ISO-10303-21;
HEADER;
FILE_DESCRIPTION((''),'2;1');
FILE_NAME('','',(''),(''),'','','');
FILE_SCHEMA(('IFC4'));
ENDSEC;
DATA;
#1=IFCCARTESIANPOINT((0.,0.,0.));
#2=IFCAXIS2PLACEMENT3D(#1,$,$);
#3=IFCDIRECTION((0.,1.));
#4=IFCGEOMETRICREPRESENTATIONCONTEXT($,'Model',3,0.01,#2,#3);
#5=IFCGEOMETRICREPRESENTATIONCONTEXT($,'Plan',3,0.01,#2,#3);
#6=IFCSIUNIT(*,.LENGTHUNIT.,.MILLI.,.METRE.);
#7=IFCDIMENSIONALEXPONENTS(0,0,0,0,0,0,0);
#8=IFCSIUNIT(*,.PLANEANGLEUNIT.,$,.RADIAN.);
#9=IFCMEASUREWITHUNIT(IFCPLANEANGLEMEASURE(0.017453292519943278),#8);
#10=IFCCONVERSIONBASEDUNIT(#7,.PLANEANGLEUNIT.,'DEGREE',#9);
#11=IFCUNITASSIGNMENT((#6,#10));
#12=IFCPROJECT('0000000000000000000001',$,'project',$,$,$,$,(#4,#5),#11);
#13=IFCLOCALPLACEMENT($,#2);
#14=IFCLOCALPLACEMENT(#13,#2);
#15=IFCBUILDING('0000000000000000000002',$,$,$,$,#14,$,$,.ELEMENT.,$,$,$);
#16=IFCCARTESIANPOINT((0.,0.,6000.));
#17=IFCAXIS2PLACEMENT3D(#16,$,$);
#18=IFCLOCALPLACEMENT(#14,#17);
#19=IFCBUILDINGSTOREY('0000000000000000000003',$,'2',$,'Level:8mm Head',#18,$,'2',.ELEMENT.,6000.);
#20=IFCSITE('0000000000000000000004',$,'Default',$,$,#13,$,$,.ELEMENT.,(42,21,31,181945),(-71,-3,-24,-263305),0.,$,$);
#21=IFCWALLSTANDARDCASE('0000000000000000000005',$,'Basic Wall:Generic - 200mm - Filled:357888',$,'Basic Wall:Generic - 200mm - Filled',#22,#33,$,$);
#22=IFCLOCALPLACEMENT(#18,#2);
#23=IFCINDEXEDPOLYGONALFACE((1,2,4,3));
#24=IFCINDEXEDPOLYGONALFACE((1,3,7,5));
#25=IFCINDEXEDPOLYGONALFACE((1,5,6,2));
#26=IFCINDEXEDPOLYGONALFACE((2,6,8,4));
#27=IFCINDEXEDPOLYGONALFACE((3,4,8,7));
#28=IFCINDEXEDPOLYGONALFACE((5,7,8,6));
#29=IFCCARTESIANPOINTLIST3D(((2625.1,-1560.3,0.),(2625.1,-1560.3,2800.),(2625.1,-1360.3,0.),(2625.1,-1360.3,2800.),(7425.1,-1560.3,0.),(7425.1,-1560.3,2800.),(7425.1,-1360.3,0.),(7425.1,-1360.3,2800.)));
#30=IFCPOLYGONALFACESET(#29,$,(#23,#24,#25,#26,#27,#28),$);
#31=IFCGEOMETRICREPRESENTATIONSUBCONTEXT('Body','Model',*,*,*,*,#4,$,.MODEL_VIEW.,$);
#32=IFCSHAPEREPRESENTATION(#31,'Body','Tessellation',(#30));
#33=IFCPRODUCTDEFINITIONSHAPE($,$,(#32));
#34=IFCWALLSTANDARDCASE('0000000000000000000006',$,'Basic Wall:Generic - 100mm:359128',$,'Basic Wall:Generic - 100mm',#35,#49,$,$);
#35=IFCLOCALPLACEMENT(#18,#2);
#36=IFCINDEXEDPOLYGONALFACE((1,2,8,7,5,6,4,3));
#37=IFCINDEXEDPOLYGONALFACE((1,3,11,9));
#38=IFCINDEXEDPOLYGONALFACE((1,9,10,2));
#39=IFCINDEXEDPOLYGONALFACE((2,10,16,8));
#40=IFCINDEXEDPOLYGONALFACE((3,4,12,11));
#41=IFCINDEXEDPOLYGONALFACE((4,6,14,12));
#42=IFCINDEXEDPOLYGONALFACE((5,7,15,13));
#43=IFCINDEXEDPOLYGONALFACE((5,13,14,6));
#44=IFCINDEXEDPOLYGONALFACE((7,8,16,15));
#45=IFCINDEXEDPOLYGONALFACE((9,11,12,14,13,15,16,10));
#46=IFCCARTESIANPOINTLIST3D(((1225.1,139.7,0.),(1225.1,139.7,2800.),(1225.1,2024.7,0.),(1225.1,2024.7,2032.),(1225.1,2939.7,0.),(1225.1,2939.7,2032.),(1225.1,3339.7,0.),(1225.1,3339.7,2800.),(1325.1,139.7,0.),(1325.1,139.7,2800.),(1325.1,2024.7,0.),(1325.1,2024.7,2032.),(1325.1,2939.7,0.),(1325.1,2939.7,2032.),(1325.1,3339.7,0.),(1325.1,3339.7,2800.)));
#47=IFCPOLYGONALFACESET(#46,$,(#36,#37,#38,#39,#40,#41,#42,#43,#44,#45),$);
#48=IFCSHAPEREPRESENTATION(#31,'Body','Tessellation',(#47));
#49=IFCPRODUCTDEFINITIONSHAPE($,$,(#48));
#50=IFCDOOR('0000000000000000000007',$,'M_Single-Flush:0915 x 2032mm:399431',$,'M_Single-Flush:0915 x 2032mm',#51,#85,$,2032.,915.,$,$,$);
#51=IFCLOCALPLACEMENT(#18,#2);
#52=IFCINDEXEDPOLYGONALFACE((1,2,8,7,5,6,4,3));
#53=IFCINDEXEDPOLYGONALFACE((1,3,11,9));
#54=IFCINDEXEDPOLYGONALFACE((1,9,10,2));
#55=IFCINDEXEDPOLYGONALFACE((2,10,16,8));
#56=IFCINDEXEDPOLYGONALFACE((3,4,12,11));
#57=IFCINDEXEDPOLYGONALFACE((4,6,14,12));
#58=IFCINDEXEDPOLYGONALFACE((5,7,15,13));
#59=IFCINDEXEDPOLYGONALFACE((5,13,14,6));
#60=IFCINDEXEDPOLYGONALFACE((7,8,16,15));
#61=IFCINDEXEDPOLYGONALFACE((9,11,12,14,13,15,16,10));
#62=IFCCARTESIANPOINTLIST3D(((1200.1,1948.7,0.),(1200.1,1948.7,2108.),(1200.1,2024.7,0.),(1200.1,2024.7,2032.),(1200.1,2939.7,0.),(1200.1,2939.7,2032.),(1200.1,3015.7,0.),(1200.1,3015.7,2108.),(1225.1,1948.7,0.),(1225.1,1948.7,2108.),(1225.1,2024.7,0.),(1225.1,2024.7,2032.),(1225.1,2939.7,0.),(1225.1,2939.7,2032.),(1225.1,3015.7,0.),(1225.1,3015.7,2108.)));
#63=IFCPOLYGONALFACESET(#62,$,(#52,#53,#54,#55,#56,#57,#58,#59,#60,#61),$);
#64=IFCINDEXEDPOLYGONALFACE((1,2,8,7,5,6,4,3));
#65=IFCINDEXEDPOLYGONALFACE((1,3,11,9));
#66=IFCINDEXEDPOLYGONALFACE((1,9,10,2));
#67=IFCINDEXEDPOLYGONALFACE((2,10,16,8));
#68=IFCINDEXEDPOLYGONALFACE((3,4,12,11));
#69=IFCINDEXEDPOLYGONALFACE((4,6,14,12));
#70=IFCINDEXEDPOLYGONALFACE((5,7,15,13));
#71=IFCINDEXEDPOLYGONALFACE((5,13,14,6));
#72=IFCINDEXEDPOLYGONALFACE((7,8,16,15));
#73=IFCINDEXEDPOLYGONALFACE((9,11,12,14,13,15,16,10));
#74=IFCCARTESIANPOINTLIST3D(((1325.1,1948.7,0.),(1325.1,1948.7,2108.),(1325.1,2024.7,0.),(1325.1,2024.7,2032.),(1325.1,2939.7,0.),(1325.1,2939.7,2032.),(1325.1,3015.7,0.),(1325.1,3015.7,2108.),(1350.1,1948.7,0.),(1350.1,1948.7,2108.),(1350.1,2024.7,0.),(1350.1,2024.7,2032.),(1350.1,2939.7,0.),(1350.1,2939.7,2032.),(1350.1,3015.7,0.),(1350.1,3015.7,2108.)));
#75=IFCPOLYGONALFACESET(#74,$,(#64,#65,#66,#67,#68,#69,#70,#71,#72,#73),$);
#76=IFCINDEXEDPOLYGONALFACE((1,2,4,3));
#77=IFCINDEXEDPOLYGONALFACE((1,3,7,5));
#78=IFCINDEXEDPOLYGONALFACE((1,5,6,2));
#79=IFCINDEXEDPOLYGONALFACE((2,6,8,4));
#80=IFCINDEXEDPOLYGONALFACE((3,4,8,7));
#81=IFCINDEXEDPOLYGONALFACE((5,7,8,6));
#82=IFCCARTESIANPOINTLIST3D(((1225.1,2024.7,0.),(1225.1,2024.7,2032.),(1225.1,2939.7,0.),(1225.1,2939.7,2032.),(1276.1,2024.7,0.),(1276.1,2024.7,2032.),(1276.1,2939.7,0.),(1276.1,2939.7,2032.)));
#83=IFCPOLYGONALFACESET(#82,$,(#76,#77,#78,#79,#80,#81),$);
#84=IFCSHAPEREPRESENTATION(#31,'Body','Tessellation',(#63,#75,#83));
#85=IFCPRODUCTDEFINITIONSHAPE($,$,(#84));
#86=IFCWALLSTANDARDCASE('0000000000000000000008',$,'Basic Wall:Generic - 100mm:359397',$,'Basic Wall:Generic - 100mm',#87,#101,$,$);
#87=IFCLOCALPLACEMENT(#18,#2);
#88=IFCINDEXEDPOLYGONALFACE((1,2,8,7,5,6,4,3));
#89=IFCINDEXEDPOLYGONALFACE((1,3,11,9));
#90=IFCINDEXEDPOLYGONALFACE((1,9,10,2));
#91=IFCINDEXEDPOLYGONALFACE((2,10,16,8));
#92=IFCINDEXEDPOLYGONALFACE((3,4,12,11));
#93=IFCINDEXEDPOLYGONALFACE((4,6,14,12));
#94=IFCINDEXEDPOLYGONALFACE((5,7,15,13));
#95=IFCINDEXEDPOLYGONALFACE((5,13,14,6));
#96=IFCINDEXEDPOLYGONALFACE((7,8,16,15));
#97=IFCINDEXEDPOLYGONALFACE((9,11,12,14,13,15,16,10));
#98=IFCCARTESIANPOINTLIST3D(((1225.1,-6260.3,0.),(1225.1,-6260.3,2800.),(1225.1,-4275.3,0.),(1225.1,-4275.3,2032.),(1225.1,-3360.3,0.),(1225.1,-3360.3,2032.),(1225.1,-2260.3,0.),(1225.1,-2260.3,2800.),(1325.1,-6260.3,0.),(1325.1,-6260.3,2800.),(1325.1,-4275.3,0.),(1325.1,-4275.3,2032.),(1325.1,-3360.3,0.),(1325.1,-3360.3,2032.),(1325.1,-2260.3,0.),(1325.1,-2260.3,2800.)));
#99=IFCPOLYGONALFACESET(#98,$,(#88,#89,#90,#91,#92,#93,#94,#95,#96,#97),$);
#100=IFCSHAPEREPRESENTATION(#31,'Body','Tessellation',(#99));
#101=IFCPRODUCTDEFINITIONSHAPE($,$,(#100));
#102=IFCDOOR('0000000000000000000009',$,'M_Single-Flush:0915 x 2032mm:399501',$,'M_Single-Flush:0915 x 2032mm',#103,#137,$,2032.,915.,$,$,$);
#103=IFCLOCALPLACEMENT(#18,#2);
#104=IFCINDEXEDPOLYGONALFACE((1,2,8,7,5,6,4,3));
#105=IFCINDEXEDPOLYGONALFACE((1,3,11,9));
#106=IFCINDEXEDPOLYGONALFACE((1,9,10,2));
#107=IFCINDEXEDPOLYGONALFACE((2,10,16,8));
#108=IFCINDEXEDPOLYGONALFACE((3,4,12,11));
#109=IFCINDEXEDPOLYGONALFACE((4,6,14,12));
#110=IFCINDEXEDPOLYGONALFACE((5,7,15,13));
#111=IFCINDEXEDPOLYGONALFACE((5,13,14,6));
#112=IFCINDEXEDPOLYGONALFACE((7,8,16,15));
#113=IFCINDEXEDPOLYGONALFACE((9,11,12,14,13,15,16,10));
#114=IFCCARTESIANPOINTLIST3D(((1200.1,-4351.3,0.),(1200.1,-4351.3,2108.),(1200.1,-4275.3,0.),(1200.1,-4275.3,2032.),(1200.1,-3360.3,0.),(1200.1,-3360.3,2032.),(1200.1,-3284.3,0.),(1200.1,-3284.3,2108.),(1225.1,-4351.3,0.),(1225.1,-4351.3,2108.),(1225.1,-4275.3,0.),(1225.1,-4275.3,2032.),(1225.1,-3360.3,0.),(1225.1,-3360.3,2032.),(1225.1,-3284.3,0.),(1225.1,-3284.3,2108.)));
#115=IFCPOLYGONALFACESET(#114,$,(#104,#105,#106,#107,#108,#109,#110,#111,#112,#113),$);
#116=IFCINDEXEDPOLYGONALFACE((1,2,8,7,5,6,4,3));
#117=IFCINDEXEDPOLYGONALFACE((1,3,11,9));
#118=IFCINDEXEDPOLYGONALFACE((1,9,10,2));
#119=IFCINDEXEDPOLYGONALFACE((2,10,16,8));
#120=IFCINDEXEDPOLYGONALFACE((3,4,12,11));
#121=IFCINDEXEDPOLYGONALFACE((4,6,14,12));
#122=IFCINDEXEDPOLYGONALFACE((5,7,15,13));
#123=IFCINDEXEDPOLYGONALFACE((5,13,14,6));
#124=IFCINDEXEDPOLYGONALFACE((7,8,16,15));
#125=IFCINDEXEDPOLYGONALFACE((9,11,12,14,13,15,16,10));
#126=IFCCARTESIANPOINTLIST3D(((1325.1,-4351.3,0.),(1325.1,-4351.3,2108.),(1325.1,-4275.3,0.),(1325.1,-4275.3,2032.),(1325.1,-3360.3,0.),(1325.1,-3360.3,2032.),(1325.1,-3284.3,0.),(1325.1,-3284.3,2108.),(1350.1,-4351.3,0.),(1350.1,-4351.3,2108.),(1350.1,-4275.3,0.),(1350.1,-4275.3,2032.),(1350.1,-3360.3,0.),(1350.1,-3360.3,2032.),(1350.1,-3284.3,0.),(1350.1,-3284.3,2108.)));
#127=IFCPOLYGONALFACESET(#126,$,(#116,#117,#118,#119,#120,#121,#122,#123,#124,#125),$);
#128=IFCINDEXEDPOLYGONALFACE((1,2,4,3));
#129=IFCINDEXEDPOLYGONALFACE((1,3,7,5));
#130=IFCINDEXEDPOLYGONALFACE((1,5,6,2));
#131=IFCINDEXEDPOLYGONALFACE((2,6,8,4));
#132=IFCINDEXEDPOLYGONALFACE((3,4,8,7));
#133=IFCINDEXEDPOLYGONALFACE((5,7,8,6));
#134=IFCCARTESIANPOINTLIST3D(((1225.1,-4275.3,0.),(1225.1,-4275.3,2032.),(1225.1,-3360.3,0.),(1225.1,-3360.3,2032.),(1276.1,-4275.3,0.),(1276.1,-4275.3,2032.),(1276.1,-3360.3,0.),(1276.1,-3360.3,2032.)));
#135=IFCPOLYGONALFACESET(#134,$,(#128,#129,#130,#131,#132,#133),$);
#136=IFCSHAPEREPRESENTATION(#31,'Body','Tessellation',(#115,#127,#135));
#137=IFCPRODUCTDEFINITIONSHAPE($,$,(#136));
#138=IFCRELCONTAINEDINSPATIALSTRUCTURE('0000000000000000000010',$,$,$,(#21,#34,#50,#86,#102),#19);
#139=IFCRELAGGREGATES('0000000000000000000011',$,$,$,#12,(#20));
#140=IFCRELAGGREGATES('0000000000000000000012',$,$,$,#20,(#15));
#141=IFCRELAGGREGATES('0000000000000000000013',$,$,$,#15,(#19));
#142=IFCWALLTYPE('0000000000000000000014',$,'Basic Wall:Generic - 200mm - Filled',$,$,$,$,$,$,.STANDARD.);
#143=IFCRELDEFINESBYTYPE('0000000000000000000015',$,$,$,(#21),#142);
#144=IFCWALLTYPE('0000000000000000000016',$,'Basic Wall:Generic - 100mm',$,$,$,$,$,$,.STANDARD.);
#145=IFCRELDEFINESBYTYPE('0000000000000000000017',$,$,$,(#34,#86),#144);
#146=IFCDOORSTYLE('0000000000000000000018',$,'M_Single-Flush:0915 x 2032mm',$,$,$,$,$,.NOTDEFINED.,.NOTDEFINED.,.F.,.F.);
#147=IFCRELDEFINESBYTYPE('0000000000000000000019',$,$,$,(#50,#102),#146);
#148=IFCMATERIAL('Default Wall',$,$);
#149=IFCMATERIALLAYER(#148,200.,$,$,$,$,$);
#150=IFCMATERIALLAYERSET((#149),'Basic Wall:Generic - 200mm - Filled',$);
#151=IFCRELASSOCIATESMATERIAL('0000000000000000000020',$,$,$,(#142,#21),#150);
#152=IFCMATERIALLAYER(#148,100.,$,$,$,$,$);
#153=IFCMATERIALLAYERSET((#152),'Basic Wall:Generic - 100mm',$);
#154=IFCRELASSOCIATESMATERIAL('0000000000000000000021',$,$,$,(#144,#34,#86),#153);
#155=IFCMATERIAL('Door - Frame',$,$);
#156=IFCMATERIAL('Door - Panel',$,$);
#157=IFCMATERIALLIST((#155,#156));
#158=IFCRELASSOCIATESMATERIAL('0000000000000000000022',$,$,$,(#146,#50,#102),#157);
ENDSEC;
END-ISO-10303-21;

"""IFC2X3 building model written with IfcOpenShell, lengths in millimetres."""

from ifc_helpers import new_model, entity, si_unit, converted_unit, direction, frame, frame_2d, origin, origin_2d_with_axis, place, context, subcontext, project, spatial, polyline, rectangle, outline, extrude, source, transform, mapped, material, material_list, layer, layer_set, layer_usage, type_object, type_shapes, element, fill, save


model = new_model("IFC2X3")

# Units and contexts
model_context = context("Model", 3, precision=0.01, world=origin(), true_north=direction((0.0, 1.0)))
plan_context = context("Plan", 3, precision=0.01, world=origin(), true_north=direction((0.0, 1.0)))
body_context = subcontext(model_context, "Body", "Model", "MODEL_VIEW")
ifc_project = project(units=[si_unit("LENGTHUNIT", "METRE", prefix="MILLI"), converted_unit("PLANEANGLEUNIT", "DEGREE", entity("IfcPlaneAngleMeasure", 0.017453292519943278), si_unit("PLANEANGLEUNIT", "RADIAN"), dimensions=[0, 0, 0, 0, 0, 0, 0])], contexts=[model_context, plan_context])

# Site, building, storey
site_placement = place(None, origin())
site = spatial("IfcSite", under=ifc_project, at=site_placement, Name="Default", CompositionType="ELEMENT", RefLatitude=(42, 21, 31, 181945), RefLongitude=(-71, -3, -24, -263305), RefElevation=0.0)
building_placement = place(site_placement, origin())
building = spatial("IfcBuilding", under=site, at=building_placement, CompositionType="ELEMENT")
storey_placement = place(building_placement, frame((0.0, 0.0, 6000.0)))
storey = spatial("IfcBuildingStorey", under=building, at=storey_placement, Name="2", ObjectType="Level:8mm Head", LongName="2", CompositionType="ELEMENT", Elevation=6000.0)

# Shared definitions
ifc_material_1 = material(Name="Default Wall")
ifc_layer_1 = layer(ifc_material_1, 200.0)
ifc_layer_set_1 = layer_set([ifc_layer_1], Name="Basic Wall:Generic - 200mm - Filled")
ifc_layer_usage_1 = layer_usage(ifc_layer_set_1, "AXIS2", "NEGATIVE", 100.0)
wall_type_1 = type_object("IfcWallType", Name="Basic Wall:Generic - 200mm - Filled", PredefinedType="STANDARD", material=ifc_layer_set_1)
ifc_material_2 = material(Name="Door - Frame")
ifc_material_3 = material(Name="Door - Panel")
ifc_material_list = material_list([ifc_material_2, ifc_material_3])

# Wall
wall_1_placement = place(storey_placement, frame((2625.1, -1460.3, 0.0)))
element("IfcWallStandardCase", 1, at=wall_1_placement, inside=storey, type_object=wall_type_1, material=ifc_layer_usage_1, Name="Basic Wall:Generic - 200mm - Filled:357888", ObjectType="Basic Wall:Generic - 200mm - Filled", context=body_context, shape_type="SweptSolid", body=[
    extrude(rectangle(XDim=4800.0, YDim=200.0, at=frame_2d((2400.0, 0.0), x_axis=(-1.0, 0.0))), origin(), (0.0, 0.0, 1.0), 2800.0),
])

# Walls, openings, doors
ifc_layer_2 = layer(ifc_material_1, 100.0)
ifc_layer_set_2 = layer_set([ifc_layer_2], Name="Basic Wall:Generic - 100mm")
ifc_layer_usage_2 = layer_usage(ifc_layer_set_2, "AXIS2", "NEGATIVE", 50.0)
wall_type_2 = type_object("IfcWallType", Name="Basic Wall:Generic - 100mm", PredefinedType="STANDARD", material=ifc_layer_set_2)
wall_2_placement = place(storey_placement, frame((1275.1, 139.7, 0.0), z_axis=(0.0, 0.0, 1.0), x_axis=(0.0, 1.0, 0.0)))
wall_2 = element("IfcWallStandardCase", 2, at=wall_2_placement, inside=storey, type_object=wall_type_2, material=ifc_layer_usage_2, Name="Basic Wall:Generic - 100mm:359128", ObjectType="Basic Wall:Generic - 100mm", context=body_context, shape_type="SweptSolid", body=[
    extrude(rectangle(XDim=3200.0, YDim=100.0, at=frame_2d((1600.0, 0.0), x_axis=(-1.0, 0.0))), origin(), (0.0, 0.0, 1.0), 2800.0),
])
opening_1_placement = place(wall_2_placement, frame((1885.0, -50.0, 0.0)))
opening_1 = element("IfcOpeningElement", 3, at=opening_1_placement, cuts=wall_2, ObjectType="Opening", context=body_context, shape_type="SweptSolid", body=[
    extrude(rectangle(XDim=915.0, YDim=2032.0, at=frame_2d((1016.0, 457.5), x_axis=(0.0, 1.0))), frame((0.0, 0.0, 0.0), z_axis=(0.0, 1.0, 0.0), x_axis=(0.0, 0.0, 1.0)), (0.0, 0.0, 1.0), 100.0),
])
door_style_1 = type_object("IfcDoorStyle", Name="M_Single-Flush:0915 x 2032mm", ConstructionType="NOTDEFINED", OperationType="NOTDEFINED", ParameterTakesPrecedence=False, Sizeable=False, material=ifc_material_list)
shared_shape_1 = source(origin(), body_context, "Body", "SweptSolid", [
    extrude(outline(polyline([(-533.5, -1073.0), (533.5, -1073.0), (533.5, 1035.0), (457.5, 1035.0), (457.5, -997.0), (-457.5, -997.0), (-457.5, 1035.0), (-533.5, 1035.0), (-533.5, -1073.0)])), frame((457.5, 100.0, 1035.0), z_axis=(0.0, 1.0, 0.0), x_axis=(1.0, 0.0, 0.0)), (0.0, 0.0, 1.0), 25.0),
    extrude(outline(polyline([(-1073.0, -533.5), (1035.0, -533.5), (1035.0, -457.5), (-997.0, -457.5), (-997.0, 457.5), (1035.0, 457.5), (1035.0, 533.5), (-1073.0, 533.5), (-1073.0, -533.5)])), frame((457.5, -25.0, 1035.0), z_axis=(0.0, 1.0, 0.0), x_axis=(0.0, 0.0, -1.0)), (0.0, 0.0, 1.0), 25.0),
    extrude(rectangle(XDim=51.0, YDim=915.0, at=origin_2d_with_axis()), frame((457.5, 74.5, 0.0), z_axis=(0.0, 0.0, 1.0), x_axis=(0.0, 1.0, 0.0)), (0.0, 0.0, 1.0), 2032.0),
])
type_shapes(door_style_1, [shared_shape_1])
door_1_placement = place(opening_1_placement, origin())
door_1 = element("IfcDoor", 4, at=door_1_placement, inside=storey, type_object=door_style_1, material=ifc_material_list, Name="M_Single-Flush:0915 x 2032mm:399431", ObjectType="M_Single-Flush:0915 x 2032mm", OverallHeight=2032.0, OverallWidth=915.0, context=body_context, shape_type="MappedRepresentation", body=[
    mapped(shared_shape_1, transform((0.0, 0.0, 0.0), scale=1.0)),
])
fill(opening_1, door_1)
wall_3_placement = place(storey_placement, frame((1275.1, -2260.3, 0.0), z_axis=(0.0, 0.0, 1.0), x_axis=(0.0, -1.0, 0.0)))
wall_3 = element("IfcWallStandardCase", 5, at=wall_3_placement, inside=storey, type_object=wall_type_2, material=ifc_layer_usage_2, Name="Basic Wall:Generic - 100mm:359397", ObjectType="Basic Wall:Generic - 100mm", context=body_context, shape_type="SweptSolid", body=[
    extrude(rectangle(XDim=4000.0, YDim=100.0, at=frame_2d((2000.0, 0.0), x_axis=(1.0, 0.0))), origin(), (0.0, 0.0, 1.0), 2800.0),
])
opening_2_placement = place(wall_3_placement, frame((2015.0, 50.0, 0.0)))
opening_2 = element("IfcOpeningElement", 6, at=opening_2_placement, cuts=wall_3, ObjectType="Opening", context=body_context, shape_type="SweptSolid", body=[
    extrude(rectangle(XDim=915.0, YDim=2032.0, at=frame_2d((1016.0, 457.5), x_axis=(0.0, 1.0))), frame((0.0, 0.0, 0.0), z_axis=(0.0, -1.0, 0.0), x_axis=(0.0, 0.0, 1.0)), (0.0, 0.0, 1.0), 100.0),
])
door_2_placement = place(opening_2_placement, frame((0.0, 0.0, 0.0), z_axis=(0.0, 0.0, 1.0), x_axis=(-1.0, 0.0, 0.0)))
door_2 = element("IfcDoor", 7, at=door_2_placement, inside=storey, type_object=door_style_1, material=ifc_material_list, Name="M_Single-Flush:0915 x 2032mm:399501", ObjectType="M_Single-Flush:0915 x 2032mm", OverallHeight=2032.0, OverallWidth=915.0, context=body_context, shape_type="MappedRepresentation", body=[
    mapped(shared_shape_1, transform((0.0, 0.0, 0.0), scale=1.0)),
])
fill(opening_2, door_2)

save(model, "model.ifc")
